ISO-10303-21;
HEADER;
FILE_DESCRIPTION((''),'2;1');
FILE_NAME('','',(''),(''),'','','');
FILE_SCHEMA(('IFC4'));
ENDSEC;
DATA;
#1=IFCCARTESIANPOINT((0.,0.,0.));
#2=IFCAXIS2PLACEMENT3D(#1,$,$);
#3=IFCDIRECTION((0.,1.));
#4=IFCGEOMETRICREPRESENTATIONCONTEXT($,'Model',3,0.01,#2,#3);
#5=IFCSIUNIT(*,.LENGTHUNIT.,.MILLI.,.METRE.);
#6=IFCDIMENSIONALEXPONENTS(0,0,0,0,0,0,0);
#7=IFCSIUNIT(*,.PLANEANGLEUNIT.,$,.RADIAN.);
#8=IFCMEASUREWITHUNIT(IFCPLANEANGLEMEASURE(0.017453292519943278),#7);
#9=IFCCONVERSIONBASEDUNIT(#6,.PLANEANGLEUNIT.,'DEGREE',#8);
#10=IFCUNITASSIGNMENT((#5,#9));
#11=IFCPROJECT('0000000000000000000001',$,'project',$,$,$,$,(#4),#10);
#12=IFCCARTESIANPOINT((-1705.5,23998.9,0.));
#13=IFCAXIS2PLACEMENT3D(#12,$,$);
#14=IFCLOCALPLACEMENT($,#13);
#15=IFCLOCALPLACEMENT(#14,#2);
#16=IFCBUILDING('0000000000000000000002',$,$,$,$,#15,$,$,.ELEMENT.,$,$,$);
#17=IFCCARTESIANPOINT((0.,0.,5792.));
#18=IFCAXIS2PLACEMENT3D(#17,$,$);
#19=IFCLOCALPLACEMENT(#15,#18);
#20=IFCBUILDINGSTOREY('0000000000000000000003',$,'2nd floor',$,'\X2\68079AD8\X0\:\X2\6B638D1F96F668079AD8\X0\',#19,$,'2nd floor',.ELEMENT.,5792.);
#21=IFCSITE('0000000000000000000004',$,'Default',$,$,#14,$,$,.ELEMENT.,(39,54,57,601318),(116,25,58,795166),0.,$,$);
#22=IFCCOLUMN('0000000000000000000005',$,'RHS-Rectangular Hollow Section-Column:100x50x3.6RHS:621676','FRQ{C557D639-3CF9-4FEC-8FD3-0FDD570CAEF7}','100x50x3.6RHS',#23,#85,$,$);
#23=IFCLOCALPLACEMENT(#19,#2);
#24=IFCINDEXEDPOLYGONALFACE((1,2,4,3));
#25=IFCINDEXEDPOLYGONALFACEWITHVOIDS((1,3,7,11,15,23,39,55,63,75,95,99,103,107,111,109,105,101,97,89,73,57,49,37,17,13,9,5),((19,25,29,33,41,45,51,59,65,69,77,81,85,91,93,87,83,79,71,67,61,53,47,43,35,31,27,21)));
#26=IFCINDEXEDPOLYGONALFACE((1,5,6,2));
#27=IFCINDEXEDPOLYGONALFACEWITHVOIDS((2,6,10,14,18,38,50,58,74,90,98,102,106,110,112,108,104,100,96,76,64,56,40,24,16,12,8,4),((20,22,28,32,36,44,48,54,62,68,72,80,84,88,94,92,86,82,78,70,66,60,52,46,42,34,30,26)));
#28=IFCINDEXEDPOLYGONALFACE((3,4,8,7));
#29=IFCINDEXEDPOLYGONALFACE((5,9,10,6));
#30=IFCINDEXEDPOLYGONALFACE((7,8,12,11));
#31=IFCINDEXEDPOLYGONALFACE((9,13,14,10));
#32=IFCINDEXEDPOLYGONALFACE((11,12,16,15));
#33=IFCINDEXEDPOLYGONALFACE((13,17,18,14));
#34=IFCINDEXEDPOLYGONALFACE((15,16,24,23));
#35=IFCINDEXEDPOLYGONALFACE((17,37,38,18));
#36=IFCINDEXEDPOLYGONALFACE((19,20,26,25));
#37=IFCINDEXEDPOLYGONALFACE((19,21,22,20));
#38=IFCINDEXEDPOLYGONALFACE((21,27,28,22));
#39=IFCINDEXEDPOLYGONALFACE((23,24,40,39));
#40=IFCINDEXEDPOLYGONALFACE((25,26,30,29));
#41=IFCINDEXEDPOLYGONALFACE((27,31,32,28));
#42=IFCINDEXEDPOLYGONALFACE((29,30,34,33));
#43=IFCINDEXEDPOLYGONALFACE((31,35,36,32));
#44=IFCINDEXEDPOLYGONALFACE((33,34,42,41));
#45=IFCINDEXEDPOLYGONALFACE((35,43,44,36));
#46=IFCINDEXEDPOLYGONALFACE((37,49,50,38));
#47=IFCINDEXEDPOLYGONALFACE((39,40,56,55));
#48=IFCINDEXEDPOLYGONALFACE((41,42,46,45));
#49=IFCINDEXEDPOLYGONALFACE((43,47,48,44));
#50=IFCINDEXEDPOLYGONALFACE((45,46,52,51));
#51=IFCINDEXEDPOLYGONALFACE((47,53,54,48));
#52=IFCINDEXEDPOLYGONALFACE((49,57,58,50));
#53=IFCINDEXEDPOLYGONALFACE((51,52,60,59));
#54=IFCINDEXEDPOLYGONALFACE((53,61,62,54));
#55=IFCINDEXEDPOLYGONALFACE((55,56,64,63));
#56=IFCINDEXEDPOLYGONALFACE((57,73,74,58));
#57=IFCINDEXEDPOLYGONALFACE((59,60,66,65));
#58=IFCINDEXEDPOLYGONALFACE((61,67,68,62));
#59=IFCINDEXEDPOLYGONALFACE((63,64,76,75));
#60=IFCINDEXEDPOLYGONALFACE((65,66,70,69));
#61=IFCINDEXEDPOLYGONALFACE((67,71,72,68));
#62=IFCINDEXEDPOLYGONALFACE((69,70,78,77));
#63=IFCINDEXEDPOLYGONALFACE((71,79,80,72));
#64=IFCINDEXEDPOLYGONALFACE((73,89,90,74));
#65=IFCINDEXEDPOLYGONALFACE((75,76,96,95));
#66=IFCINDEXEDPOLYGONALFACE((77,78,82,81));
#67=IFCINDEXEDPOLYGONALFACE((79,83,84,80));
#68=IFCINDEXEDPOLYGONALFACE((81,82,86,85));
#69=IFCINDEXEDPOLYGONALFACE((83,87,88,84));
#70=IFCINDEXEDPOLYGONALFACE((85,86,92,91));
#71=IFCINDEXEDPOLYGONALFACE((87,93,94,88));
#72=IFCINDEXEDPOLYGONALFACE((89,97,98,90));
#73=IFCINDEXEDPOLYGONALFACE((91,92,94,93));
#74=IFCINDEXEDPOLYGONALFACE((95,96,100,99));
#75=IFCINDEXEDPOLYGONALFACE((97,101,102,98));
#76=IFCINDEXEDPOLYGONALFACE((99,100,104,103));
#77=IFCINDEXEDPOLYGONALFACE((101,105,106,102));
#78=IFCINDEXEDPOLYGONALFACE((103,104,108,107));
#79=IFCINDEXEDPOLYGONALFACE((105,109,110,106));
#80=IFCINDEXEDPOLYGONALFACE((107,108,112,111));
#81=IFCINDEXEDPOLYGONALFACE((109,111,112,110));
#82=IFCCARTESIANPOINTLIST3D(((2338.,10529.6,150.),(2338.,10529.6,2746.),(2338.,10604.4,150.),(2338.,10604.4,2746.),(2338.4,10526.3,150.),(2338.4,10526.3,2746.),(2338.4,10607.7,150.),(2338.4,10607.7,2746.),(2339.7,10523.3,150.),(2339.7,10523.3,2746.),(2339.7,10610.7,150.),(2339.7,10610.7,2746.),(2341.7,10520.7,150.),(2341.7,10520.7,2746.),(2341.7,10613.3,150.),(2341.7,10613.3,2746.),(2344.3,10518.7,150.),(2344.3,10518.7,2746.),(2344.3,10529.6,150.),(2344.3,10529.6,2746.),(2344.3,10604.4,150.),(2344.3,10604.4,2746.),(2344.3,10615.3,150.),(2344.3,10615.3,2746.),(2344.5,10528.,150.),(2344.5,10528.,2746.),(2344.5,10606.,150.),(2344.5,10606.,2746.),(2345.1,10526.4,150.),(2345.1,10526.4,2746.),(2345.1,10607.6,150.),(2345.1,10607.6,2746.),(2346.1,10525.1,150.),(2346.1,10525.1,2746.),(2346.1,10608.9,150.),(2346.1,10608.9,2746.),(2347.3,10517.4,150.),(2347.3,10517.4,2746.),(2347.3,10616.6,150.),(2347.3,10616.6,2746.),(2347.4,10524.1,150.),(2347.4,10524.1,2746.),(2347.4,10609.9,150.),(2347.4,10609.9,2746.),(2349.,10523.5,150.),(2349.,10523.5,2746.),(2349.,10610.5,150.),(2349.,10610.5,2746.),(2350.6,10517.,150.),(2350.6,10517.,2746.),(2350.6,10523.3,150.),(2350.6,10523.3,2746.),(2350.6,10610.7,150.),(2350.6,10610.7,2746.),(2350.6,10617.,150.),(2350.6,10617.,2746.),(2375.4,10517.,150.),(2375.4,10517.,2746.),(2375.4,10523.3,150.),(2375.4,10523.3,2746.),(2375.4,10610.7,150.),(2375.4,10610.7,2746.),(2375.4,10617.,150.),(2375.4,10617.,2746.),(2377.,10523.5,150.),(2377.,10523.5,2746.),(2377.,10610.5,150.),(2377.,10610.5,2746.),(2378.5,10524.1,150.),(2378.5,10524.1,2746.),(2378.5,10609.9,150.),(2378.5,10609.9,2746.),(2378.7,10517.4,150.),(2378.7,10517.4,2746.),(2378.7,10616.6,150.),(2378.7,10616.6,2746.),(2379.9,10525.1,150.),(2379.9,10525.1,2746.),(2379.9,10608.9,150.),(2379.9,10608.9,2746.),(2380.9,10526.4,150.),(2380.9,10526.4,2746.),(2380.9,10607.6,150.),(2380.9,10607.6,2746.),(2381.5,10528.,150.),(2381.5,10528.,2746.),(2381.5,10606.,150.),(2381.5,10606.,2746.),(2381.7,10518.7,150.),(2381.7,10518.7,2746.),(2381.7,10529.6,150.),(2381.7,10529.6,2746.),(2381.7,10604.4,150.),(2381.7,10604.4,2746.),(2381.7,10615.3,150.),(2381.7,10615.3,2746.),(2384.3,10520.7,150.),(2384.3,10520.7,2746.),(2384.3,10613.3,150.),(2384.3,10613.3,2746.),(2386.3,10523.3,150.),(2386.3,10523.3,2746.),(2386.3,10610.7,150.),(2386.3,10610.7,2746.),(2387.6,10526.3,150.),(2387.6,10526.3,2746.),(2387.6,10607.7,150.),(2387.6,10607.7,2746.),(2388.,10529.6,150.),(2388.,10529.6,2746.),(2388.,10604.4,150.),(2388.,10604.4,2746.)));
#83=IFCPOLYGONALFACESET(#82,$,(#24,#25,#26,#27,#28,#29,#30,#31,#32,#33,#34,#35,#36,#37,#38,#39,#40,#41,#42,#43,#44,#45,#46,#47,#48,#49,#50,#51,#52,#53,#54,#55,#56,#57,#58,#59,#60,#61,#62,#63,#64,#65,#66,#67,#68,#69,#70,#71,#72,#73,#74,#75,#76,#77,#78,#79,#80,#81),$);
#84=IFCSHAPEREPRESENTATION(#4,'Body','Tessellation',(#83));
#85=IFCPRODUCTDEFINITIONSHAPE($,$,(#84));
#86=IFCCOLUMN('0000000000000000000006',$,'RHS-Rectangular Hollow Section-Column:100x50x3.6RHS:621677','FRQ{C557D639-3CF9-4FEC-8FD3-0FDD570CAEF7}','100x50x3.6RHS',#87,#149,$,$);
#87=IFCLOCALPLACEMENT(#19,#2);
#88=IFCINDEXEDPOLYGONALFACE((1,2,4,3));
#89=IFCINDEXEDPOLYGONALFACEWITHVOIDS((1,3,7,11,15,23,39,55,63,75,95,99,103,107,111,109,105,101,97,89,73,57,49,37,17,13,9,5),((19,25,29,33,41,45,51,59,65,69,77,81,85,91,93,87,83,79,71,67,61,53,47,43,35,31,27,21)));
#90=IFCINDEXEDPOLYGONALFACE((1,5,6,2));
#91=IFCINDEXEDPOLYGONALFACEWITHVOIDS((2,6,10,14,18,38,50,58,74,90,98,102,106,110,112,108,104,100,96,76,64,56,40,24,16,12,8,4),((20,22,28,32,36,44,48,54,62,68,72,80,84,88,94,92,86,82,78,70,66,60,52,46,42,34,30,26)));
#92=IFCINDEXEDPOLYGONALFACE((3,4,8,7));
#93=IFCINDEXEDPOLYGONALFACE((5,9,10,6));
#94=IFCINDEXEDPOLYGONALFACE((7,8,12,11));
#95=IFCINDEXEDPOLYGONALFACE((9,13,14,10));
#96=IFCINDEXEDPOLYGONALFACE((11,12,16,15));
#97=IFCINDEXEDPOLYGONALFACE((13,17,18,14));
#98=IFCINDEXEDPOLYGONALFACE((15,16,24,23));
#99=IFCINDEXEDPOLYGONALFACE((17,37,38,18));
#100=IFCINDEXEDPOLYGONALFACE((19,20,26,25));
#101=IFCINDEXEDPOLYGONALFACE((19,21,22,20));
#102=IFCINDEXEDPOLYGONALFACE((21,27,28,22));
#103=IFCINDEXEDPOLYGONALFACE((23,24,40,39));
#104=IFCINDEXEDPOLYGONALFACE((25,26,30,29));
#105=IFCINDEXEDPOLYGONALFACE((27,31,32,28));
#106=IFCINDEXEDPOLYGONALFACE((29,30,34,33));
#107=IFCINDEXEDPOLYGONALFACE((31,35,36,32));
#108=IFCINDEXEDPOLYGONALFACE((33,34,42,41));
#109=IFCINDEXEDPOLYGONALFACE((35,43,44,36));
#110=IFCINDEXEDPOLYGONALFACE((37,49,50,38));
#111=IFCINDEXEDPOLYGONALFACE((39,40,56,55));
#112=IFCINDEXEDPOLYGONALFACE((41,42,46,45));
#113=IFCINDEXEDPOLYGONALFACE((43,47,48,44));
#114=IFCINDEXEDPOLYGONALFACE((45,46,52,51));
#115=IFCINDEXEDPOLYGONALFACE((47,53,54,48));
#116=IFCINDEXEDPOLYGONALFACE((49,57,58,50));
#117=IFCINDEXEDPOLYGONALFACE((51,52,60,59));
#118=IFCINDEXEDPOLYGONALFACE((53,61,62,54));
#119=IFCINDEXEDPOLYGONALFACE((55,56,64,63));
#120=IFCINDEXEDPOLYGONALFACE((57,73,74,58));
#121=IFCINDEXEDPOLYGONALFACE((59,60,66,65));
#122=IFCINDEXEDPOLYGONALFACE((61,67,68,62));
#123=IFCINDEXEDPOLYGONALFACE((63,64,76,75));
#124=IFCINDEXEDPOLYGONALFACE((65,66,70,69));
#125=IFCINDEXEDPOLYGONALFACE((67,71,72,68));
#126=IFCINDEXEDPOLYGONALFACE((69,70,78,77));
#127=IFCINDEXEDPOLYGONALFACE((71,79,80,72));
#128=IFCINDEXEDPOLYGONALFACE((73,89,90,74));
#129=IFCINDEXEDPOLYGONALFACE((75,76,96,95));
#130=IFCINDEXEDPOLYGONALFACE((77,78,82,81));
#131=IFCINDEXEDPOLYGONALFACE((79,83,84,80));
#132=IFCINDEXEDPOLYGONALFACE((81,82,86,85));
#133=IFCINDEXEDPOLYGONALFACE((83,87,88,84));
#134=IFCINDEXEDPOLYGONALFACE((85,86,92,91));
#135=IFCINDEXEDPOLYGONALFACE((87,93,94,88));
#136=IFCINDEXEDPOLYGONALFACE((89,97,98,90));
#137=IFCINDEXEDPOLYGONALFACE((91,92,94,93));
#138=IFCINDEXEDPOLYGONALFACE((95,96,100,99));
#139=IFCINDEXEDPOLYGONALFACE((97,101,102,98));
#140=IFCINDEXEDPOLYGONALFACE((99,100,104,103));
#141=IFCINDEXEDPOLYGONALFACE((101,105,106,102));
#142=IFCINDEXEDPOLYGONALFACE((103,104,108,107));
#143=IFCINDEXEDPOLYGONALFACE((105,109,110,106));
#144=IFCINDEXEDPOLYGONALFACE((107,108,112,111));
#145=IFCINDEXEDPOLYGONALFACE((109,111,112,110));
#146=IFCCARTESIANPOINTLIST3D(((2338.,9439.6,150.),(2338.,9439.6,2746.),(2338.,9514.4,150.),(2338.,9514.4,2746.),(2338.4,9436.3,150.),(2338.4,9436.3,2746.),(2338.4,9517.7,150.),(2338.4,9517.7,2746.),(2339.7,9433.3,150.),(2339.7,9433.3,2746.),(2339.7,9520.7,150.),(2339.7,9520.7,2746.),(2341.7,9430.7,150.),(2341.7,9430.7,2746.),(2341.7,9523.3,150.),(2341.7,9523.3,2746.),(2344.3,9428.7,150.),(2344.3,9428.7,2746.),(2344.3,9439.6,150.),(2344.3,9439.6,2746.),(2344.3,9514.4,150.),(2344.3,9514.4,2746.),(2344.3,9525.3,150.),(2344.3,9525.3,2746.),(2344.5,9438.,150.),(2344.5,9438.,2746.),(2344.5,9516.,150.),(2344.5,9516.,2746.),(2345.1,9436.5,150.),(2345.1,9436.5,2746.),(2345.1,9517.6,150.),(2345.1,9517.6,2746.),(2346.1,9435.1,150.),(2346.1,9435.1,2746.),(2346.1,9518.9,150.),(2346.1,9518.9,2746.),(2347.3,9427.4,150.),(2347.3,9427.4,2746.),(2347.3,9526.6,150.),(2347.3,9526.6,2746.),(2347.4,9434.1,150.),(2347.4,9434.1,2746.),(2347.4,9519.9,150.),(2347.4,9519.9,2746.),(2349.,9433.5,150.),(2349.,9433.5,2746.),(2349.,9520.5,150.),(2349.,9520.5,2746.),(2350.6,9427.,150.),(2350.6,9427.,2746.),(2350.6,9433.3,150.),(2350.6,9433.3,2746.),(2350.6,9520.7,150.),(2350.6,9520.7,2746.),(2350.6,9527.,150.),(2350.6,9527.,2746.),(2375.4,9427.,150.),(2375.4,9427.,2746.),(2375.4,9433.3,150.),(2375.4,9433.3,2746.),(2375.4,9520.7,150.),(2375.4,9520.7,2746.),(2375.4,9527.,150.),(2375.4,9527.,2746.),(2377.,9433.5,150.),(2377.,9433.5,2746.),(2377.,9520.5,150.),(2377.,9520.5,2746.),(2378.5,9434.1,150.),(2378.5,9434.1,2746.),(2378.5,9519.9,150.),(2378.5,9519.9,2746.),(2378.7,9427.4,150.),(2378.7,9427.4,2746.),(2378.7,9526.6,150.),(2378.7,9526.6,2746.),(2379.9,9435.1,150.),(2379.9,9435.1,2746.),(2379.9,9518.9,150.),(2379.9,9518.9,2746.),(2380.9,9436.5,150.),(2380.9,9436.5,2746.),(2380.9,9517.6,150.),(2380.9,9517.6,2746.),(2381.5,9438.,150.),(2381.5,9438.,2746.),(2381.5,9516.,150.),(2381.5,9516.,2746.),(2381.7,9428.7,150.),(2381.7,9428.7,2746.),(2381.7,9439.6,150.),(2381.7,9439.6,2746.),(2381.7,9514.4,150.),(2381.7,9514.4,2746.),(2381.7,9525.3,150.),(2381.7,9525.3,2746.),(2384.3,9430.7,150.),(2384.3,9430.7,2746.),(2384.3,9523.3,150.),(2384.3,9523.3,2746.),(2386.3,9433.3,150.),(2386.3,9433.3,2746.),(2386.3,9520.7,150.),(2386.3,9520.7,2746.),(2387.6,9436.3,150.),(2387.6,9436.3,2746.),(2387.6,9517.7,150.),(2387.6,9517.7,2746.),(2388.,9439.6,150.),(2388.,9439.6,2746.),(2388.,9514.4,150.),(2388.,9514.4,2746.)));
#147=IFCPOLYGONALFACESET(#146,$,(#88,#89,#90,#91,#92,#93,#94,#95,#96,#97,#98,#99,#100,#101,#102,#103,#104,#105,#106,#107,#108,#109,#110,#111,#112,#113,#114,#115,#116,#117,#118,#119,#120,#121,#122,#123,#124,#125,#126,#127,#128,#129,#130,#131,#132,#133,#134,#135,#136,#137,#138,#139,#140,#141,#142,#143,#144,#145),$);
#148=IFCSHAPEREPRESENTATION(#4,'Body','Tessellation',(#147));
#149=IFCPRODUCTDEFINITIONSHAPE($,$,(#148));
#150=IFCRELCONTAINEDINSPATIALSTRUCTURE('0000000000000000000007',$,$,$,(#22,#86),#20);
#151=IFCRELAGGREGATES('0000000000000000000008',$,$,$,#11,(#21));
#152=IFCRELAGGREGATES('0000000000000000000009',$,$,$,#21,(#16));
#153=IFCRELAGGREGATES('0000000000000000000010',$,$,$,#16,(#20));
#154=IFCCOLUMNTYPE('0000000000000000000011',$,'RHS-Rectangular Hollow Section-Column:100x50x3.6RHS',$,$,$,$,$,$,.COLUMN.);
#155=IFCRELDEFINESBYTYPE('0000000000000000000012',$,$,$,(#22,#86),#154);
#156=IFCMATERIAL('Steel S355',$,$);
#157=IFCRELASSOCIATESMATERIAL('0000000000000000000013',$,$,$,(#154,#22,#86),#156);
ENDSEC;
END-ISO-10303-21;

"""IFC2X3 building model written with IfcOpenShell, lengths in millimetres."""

from ifc_helpers import new_model, entity, si_unit, converted_unit, direction, frame, origin, origin_2d, place, context, project, spatial, hollow_rectangle, extrude, clip, halfspace, material, type_object, element, save


model = new_model("IFC2X3")

# Units and contexts
model_context = context("Model", 3, precision=0.01, world=origin(), true_north=direction((0.0, 1.0)))
ifc_project = project(units=[si_unit("LENGTHUNIT", "METRE", prefix="MILLI"), converted_unit("PLANEANGLEUNIT", "DEGREE", entity("IfcPlaneAngleMeasure", 0.017453292519943278), si_unit("PLANEANGLEUNIT", "RADIAN"), dimensions=[0, 0, 0, 0, 0, 0, 0])], contexts=[model_context])

# Site, building, storey
site_placement = place(None, frame((-1705.5, 23998.9, 0.0)))
site = spatial("IfcSite", under=ifc_project, at=site_placement, Name="Default", CompositionType="ELEMENT", RefLatitude=(39, 54, 57, 601318), RefLongitude=(116, 25, 58, 795166), RefElevation=0.0)
building_placement = place(site_placement, origin())
building = spatial("IfcBuilding", under=site, at=building_placement, CompositionType="ELEMENT")
storey_placement = place(building_placement, frame((0.0, 0.0, 5792.0)))
storey = spatial("IfcBuildingStorey", under=building, at=storey_placement, Name="2nd floor", ObjectType="标高:正负零标高", LongName="2nd floor", CompositionType="ELEMENT", Elevation=5792.0)

# Columns
ifc_material_1 = material(Name="Steel S355")
column_type = type_object("IfcColumnType", Name="RHS-Rectangular Hollow Section-Column:100x50x3.6RHS", PredefinedType="COLUMN", material=ifc_material_1)
column_1_placement = place(storey_placement, frame((2363.0, 10567.0, 2746.0), z_axis=(0.0, 0.0, 1.0), x_axis=(-1.0, 0.0, 0.0)))
element("IfcColumn", 1, at=column_1_placement, inside=storey, type_object=column_type, material=ifc_material_1, Name="RHS-Rectangular Hollow Section-Column:100x50x3.6RHS:621676", Description="FRQ{C557D639-3CF9-4FEC-8FD3-0FDD570CAEF7}", ObjectType="100x50x3.6RHS", context=model_context, shape_type="Clipping", body=[
    clip(extrude(hollow_rectangle(XDim=50.0, YDim=100.0, WallThickness=6.3, InnerFilletRadius=6.3, OuterFilletRadius=12.6, at=origin_2d()), origin(), (0.0, 0.0, -1.0), 2651.9), halfspace(frame((2363.0, 10567.0, -2596.0), z_axis=(0.0, 0.0, 1.0), x_axis=(-1.0, 0.0, 0.0)), True)),
])
column_2_placement = place(storey_placement, frame((2363.0, 9477.0, 2746.0), z_axis=(0.0, 0.0, 1.0), x_axis=(-1.0, 0.0, 0.0)))
element("IfcColumn", 2, at=column_2_placement, inside=storey, type_object=column_type, material=ifc_material_1, Name="RHS-Rectangular Hollow Section-Column:100x50x3.6RHS:621677", Description="FRQ{C557D639-3CF9-4FEC-8FD3-0FDD570CAEF7}", ObjectType="100x50x3.6RHS", context=model_context, shape_type="Clipping", body=[
    clip(extrude(hollow_rectangle(XDim=50.0, YDim=100.0, WallThickness=6.3, InnerFilletRadius=6.3, OuterFilletRadius=12.6, at=origin_2d()), origin(), (0.0, 0.0, -1.0), 2651.9), halfspace(frame((2363.0, 9477.0, -2596.0), z_axis=(0.0, 0.0, 1.0), x_axis=(-1.0, 0.0, 0.0)), True)),
])

save(model, "model.ifc")
